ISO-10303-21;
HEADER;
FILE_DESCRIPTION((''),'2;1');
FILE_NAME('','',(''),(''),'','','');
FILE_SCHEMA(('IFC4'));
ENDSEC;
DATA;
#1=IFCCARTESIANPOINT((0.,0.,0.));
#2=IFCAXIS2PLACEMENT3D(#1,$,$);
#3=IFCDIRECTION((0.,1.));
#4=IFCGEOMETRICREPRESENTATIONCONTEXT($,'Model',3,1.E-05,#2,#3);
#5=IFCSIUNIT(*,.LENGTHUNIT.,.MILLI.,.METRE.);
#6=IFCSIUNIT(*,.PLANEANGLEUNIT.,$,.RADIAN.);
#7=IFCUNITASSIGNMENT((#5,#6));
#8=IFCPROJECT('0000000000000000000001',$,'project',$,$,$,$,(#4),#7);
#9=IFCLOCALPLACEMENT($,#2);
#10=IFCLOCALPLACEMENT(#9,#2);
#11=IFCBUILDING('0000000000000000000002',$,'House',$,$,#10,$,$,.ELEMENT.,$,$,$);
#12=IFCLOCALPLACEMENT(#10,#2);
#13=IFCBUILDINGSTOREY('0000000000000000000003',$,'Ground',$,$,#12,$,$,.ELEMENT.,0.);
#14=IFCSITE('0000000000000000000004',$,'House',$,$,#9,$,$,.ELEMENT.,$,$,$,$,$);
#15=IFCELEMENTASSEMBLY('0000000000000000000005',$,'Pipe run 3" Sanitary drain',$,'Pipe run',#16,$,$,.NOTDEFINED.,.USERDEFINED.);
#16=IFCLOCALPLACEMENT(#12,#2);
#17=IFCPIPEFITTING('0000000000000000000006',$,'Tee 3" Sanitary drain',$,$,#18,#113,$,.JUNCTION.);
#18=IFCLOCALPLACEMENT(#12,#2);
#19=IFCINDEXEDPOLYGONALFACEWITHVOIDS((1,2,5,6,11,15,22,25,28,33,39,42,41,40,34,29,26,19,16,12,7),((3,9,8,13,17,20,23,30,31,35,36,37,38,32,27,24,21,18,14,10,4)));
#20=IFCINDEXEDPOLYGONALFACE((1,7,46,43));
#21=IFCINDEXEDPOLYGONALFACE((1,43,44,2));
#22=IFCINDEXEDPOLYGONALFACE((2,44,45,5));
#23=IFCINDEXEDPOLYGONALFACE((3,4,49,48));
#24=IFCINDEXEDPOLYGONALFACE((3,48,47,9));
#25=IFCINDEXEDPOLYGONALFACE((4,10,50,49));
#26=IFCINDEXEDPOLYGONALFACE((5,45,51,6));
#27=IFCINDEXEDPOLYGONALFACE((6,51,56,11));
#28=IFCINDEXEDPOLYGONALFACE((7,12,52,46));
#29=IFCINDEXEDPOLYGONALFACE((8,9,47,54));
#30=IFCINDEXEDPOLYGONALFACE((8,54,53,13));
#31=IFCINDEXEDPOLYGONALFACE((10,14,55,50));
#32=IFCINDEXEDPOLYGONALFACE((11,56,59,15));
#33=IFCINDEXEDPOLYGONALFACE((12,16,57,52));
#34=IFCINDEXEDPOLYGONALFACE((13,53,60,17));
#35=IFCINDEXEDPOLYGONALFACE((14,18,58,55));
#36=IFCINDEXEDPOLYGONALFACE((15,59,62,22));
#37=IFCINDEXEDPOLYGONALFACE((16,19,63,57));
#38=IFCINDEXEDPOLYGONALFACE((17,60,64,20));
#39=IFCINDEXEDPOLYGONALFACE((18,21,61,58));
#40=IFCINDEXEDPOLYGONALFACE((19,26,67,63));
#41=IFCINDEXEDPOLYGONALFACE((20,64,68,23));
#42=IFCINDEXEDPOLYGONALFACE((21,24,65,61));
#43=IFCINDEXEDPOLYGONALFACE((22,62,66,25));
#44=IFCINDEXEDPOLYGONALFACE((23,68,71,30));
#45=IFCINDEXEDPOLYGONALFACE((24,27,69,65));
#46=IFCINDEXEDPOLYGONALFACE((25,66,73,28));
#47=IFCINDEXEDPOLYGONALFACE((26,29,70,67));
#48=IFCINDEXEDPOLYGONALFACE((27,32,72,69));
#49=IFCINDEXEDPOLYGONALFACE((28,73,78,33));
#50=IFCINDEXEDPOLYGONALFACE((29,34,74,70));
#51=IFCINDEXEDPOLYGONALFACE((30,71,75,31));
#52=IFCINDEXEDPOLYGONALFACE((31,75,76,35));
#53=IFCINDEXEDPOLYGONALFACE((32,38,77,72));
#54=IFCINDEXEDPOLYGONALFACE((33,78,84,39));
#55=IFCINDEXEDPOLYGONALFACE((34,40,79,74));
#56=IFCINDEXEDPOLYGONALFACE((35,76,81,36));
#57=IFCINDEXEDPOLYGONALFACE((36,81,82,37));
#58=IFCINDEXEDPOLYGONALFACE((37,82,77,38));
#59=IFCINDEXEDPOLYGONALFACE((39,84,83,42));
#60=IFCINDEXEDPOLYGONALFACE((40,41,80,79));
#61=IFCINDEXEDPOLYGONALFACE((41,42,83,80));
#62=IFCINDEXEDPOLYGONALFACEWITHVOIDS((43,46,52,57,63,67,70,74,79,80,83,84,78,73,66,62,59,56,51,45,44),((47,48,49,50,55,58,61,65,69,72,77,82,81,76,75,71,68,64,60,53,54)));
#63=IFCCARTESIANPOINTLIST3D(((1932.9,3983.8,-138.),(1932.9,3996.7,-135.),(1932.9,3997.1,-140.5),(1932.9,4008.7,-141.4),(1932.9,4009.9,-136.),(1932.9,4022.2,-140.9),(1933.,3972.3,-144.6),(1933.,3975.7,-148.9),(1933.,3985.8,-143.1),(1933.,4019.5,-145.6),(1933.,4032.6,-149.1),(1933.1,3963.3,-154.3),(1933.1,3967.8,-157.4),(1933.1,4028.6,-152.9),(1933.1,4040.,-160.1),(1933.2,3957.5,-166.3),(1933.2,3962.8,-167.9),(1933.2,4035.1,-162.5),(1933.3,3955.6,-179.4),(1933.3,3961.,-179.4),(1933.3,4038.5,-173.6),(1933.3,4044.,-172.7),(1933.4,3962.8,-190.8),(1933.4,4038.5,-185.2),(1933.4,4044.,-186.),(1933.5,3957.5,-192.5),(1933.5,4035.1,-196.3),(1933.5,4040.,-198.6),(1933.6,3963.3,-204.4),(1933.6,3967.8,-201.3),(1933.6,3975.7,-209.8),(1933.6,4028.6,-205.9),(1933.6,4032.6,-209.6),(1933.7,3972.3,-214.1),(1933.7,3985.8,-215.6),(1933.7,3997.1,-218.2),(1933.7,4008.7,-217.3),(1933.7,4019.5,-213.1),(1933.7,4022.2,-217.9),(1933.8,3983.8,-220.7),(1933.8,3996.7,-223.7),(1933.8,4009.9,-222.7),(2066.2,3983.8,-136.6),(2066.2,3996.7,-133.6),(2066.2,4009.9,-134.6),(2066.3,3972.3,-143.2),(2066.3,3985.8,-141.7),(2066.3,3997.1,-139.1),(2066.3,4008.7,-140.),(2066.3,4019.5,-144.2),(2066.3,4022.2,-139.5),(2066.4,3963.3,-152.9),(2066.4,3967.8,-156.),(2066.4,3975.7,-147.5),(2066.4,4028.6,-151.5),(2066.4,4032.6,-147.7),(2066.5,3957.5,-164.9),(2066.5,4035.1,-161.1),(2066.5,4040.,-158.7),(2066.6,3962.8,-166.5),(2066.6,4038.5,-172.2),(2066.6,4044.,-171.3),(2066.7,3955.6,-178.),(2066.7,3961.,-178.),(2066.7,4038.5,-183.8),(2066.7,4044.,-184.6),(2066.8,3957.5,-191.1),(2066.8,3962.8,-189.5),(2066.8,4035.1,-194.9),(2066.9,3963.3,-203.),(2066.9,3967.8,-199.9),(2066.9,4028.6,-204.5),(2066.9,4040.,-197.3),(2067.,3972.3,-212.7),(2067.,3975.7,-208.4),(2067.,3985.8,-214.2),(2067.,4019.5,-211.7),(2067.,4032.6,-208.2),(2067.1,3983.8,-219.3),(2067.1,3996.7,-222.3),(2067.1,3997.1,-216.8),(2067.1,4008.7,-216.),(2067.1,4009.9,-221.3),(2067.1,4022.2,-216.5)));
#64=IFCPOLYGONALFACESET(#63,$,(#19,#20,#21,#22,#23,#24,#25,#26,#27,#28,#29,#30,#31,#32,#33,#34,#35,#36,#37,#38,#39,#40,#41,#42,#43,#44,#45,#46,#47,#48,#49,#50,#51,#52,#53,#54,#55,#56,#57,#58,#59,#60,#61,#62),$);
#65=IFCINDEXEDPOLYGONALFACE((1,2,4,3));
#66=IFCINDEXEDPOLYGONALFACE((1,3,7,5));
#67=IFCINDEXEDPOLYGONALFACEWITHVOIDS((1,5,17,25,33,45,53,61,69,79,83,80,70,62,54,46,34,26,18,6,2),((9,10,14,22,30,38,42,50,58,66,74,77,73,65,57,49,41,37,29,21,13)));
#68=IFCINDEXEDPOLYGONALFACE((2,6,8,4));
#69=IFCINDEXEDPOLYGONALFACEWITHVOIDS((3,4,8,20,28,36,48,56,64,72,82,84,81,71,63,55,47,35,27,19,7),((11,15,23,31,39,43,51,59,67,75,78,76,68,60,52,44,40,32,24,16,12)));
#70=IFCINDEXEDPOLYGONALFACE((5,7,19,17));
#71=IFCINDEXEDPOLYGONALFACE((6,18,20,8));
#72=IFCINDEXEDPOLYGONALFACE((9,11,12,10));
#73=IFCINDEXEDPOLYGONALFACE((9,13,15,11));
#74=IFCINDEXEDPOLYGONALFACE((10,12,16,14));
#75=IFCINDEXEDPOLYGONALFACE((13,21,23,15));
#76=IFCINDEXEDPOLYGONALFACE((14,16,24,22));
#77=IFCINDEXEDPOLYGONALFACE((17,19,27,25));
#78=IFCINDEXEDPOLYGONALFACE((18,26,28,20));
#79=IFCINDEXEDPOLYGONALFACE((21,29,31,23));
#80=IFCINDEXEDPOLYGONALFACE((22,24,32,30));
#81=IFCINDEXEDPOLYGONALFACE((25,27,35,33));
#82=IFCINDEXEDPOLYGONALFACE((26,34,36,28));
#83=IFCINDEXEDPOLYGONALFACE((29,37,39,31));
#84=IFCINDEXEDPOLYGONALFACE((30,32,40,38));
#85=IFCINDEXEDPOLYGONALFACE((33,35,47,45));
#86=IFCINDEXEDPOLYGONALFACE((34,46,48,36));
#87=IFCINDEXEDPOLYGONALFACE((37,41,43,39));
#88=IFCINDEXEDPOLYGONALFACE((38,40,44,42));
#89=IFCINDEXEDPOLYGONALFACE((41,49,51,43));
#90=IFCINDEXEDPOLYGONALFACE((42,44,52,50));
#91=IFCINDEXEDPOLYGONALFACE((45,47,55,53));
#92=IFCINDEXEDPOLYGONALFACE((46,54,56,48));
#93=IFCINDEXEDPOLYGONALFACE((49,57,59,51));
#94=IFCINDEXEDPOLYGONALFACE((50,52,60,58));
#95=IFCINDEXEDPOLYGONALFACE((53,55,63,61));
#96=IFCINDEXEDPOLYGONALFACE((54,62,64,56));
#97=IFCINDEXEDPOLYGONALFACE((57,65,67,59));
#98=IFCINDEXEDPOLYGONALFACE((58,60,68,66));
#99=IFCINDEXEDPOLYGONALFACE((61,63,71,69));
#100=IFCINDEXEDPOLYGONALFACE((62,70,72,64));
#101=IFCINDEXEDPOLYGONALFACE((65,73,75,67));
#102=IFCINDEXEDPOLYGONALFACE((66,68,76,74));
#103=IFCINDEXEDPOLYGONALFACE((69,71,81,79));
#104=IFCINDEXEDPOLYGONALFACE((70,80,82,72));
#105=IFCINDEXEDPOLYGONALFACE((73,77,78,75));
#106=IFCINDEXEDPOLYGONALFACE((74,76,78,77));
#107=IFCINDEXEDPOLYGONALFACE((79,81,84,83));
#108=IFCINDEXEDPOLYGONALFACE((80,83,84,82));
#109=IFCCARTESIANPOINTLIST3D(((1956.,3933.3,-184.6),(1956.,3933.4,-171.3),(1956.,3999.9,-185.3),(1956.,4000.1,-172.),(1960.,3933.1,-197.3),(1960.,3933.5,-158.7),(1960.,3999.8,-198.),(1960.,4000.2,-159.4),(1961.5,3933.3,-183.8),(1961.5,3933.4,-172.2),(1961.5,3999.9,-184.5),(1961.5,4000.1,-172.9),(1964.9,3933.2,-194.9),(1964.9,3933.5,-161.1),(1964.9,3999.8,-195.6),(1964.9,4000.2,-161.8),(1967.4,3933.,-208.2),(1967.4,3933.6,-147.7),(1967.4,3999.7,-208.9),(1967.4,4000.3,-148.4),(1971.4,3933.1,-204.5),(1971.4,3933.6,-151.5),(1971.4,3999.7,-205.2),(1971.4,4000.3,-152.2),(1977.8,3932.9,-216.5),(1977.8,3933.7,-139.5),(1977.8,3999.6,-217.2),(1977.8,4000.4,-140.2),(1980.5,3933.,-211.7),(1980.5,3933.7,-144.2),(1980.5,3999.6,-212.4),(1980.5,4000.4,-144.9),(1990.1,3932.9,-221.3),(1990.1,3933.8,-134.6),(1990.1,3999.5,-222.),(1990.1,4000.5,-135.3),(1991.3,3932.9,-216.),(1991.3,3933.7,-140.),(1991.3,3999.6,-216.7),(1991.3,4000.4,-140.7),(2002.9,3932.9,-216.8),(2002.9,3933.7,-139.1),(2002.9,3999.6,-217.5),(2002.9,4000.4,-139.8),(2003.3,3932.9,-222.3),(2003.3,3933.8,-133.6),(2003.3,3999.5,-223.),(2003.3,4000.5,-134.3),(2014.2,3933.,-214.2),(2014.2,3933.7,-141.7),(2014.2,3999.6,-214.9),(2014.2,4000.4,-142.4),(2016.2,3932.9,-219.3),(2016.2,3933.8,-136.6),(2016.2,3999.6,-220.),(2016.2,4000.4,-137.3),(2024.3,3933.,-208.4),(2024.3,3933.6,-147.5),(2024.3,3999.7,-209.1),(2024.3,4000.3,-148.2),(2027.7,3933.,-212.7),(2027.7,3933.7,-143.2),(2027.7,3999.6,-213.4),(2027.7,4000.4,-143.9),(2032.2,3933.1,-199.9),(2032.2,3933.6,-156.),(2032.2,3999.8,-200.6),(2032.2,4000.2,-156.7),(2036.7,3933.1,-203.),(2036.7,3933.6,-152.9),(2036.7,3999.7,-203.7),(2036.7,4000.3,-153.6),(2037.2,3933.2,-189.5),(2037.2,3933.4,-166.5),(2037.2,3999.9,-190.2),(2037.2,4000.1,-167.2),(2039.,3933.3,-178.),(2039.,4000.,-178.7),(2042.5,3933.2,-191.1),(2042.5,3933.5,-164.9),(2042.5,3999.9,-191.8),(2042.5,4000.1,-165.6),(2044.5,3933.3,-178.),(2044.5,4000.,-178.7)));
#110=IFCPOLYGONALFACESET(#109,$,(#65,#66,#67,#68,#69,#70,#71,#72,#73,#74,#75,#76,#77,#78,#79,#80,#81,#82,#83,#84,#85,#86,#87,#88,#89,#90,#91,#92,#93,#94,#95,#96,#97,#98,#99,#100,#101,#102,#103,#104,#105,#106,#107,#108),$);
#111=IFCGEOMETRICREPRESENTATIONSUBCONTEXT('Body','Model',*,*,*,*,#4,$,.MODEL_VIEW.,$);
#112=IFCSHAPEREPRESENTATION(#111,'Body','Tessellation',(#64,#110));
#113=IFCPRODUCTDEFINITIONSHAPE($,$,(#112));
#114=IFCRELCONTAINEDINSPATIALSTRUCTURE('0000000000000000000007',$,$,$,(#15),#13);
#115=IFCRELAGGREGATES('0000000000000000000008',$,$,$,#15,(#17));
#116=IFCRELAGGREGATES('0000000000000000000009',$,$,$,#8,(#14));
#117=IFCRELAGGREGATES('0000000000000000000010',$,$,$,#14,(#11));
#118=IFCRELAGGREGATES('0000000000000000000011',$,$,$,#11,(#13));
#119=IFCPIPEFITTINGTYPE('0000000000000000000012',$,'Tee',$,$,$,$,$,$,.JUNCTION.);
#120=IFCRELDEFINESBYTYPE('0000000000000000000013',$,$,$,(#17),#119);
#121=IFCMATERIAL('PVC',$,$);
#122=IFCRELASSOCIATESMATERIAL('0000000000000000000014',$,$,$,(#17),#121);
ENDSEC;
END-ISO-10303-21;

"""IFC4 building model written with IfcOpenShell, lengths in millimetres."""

from ifc_helpers import new_model, si_unit, direction, frame, origin, origin_with_axes, origin_2d, place, context, subcontext, project, spatial, hollow_circle, extrude, material, type_object, element, aggregate, save


model = new_model("IFC4")

# Units and contexts
model_context = context("Model", 3, precision=1e-05, world=origin(), true_north=direction((0.0, 1.0)))
body_context = subcontext(model_context, "Body", "Model", "MODEL_VIEW")
ifc_project = project(units=[si_unit("LENGTHUNIT", "METRE", prefix="MILLI"), si_unit("PLANEANGLEUNIT", "RADIAN")], contexts=[model_context])

# Site, building, storey
site_placement = place(None, origin())
site = spatial("IfcSite", under=ifc_project, at=site_placement, Name="House", CompositionType="ELEMENT")
building_placement = place(site_placement, origin())
building = spatial("IfcBuilding", under=site, at=building_placement, Name="House", CompositionType="ELEMENT")
storey_placement = place(building_placement, origin())
storey = spatial("IfcBuildingStorey", under=building, at=storey_placement, Name="Ground", CompositionType="ELEMENT", Elevation=0.0)

# Element assembly
ifc_material = material(Name="PVC")
assembly_1_placement = place(storey_placement, origin_with_axes())
assembly_1 = element("IfcElementAssembly", 1, at=assembly_1_placement, inside=storey, Name="Pipe run 3\" Sanitary drain", ObjectType="Pipe run", AssemblyPlace="NOTDEFINED", PredefinedType="USERDEFINED")

# Pipe fitting
pipe_fitting_type_1 = type_object("IfcPipeFittingType", Name="Tee", PredefinedType="JUNCTION")
pipe_fitting_1_placement = place(storey_placement, origin_with_axes())
pipe_fitting_1 = element("IfcPipeFitting", 2, at=pipe_fitting_1_placement, type_object=pipe_fitting_type_1, material=ifc_material, Name="Tee 3\" Sanitary drain", PredefinedType="JUNCTION", context=body_context, shape_type="SweptSolid", body=[
    extrude(hollow_circle(Radius=44.5, WallThickness=5.5, at=origin_2d()), frame((2066.7, 4000.0, -178.0), z_axis=(-0.999946, 0.0, -0.010416), x_axis=(0.0, -1.0, 0.0)), (0.0, 0.0, 1.0), 133.3),
    extrude(hollow_circle(Radius=44.5, WallThickness=5.5, at=origin_2d()), frame((2000.0, 4000.0, -178.7), z_axis=(0.0, -0.999946, 0.010416), x_axis=(1.0, 0.0, 0.0)), (0.0, 0.0, 1.0), 66.7),
])
aggregate(assembly_1, [pipe_fitting_1])

save(model, "model.ifc")
